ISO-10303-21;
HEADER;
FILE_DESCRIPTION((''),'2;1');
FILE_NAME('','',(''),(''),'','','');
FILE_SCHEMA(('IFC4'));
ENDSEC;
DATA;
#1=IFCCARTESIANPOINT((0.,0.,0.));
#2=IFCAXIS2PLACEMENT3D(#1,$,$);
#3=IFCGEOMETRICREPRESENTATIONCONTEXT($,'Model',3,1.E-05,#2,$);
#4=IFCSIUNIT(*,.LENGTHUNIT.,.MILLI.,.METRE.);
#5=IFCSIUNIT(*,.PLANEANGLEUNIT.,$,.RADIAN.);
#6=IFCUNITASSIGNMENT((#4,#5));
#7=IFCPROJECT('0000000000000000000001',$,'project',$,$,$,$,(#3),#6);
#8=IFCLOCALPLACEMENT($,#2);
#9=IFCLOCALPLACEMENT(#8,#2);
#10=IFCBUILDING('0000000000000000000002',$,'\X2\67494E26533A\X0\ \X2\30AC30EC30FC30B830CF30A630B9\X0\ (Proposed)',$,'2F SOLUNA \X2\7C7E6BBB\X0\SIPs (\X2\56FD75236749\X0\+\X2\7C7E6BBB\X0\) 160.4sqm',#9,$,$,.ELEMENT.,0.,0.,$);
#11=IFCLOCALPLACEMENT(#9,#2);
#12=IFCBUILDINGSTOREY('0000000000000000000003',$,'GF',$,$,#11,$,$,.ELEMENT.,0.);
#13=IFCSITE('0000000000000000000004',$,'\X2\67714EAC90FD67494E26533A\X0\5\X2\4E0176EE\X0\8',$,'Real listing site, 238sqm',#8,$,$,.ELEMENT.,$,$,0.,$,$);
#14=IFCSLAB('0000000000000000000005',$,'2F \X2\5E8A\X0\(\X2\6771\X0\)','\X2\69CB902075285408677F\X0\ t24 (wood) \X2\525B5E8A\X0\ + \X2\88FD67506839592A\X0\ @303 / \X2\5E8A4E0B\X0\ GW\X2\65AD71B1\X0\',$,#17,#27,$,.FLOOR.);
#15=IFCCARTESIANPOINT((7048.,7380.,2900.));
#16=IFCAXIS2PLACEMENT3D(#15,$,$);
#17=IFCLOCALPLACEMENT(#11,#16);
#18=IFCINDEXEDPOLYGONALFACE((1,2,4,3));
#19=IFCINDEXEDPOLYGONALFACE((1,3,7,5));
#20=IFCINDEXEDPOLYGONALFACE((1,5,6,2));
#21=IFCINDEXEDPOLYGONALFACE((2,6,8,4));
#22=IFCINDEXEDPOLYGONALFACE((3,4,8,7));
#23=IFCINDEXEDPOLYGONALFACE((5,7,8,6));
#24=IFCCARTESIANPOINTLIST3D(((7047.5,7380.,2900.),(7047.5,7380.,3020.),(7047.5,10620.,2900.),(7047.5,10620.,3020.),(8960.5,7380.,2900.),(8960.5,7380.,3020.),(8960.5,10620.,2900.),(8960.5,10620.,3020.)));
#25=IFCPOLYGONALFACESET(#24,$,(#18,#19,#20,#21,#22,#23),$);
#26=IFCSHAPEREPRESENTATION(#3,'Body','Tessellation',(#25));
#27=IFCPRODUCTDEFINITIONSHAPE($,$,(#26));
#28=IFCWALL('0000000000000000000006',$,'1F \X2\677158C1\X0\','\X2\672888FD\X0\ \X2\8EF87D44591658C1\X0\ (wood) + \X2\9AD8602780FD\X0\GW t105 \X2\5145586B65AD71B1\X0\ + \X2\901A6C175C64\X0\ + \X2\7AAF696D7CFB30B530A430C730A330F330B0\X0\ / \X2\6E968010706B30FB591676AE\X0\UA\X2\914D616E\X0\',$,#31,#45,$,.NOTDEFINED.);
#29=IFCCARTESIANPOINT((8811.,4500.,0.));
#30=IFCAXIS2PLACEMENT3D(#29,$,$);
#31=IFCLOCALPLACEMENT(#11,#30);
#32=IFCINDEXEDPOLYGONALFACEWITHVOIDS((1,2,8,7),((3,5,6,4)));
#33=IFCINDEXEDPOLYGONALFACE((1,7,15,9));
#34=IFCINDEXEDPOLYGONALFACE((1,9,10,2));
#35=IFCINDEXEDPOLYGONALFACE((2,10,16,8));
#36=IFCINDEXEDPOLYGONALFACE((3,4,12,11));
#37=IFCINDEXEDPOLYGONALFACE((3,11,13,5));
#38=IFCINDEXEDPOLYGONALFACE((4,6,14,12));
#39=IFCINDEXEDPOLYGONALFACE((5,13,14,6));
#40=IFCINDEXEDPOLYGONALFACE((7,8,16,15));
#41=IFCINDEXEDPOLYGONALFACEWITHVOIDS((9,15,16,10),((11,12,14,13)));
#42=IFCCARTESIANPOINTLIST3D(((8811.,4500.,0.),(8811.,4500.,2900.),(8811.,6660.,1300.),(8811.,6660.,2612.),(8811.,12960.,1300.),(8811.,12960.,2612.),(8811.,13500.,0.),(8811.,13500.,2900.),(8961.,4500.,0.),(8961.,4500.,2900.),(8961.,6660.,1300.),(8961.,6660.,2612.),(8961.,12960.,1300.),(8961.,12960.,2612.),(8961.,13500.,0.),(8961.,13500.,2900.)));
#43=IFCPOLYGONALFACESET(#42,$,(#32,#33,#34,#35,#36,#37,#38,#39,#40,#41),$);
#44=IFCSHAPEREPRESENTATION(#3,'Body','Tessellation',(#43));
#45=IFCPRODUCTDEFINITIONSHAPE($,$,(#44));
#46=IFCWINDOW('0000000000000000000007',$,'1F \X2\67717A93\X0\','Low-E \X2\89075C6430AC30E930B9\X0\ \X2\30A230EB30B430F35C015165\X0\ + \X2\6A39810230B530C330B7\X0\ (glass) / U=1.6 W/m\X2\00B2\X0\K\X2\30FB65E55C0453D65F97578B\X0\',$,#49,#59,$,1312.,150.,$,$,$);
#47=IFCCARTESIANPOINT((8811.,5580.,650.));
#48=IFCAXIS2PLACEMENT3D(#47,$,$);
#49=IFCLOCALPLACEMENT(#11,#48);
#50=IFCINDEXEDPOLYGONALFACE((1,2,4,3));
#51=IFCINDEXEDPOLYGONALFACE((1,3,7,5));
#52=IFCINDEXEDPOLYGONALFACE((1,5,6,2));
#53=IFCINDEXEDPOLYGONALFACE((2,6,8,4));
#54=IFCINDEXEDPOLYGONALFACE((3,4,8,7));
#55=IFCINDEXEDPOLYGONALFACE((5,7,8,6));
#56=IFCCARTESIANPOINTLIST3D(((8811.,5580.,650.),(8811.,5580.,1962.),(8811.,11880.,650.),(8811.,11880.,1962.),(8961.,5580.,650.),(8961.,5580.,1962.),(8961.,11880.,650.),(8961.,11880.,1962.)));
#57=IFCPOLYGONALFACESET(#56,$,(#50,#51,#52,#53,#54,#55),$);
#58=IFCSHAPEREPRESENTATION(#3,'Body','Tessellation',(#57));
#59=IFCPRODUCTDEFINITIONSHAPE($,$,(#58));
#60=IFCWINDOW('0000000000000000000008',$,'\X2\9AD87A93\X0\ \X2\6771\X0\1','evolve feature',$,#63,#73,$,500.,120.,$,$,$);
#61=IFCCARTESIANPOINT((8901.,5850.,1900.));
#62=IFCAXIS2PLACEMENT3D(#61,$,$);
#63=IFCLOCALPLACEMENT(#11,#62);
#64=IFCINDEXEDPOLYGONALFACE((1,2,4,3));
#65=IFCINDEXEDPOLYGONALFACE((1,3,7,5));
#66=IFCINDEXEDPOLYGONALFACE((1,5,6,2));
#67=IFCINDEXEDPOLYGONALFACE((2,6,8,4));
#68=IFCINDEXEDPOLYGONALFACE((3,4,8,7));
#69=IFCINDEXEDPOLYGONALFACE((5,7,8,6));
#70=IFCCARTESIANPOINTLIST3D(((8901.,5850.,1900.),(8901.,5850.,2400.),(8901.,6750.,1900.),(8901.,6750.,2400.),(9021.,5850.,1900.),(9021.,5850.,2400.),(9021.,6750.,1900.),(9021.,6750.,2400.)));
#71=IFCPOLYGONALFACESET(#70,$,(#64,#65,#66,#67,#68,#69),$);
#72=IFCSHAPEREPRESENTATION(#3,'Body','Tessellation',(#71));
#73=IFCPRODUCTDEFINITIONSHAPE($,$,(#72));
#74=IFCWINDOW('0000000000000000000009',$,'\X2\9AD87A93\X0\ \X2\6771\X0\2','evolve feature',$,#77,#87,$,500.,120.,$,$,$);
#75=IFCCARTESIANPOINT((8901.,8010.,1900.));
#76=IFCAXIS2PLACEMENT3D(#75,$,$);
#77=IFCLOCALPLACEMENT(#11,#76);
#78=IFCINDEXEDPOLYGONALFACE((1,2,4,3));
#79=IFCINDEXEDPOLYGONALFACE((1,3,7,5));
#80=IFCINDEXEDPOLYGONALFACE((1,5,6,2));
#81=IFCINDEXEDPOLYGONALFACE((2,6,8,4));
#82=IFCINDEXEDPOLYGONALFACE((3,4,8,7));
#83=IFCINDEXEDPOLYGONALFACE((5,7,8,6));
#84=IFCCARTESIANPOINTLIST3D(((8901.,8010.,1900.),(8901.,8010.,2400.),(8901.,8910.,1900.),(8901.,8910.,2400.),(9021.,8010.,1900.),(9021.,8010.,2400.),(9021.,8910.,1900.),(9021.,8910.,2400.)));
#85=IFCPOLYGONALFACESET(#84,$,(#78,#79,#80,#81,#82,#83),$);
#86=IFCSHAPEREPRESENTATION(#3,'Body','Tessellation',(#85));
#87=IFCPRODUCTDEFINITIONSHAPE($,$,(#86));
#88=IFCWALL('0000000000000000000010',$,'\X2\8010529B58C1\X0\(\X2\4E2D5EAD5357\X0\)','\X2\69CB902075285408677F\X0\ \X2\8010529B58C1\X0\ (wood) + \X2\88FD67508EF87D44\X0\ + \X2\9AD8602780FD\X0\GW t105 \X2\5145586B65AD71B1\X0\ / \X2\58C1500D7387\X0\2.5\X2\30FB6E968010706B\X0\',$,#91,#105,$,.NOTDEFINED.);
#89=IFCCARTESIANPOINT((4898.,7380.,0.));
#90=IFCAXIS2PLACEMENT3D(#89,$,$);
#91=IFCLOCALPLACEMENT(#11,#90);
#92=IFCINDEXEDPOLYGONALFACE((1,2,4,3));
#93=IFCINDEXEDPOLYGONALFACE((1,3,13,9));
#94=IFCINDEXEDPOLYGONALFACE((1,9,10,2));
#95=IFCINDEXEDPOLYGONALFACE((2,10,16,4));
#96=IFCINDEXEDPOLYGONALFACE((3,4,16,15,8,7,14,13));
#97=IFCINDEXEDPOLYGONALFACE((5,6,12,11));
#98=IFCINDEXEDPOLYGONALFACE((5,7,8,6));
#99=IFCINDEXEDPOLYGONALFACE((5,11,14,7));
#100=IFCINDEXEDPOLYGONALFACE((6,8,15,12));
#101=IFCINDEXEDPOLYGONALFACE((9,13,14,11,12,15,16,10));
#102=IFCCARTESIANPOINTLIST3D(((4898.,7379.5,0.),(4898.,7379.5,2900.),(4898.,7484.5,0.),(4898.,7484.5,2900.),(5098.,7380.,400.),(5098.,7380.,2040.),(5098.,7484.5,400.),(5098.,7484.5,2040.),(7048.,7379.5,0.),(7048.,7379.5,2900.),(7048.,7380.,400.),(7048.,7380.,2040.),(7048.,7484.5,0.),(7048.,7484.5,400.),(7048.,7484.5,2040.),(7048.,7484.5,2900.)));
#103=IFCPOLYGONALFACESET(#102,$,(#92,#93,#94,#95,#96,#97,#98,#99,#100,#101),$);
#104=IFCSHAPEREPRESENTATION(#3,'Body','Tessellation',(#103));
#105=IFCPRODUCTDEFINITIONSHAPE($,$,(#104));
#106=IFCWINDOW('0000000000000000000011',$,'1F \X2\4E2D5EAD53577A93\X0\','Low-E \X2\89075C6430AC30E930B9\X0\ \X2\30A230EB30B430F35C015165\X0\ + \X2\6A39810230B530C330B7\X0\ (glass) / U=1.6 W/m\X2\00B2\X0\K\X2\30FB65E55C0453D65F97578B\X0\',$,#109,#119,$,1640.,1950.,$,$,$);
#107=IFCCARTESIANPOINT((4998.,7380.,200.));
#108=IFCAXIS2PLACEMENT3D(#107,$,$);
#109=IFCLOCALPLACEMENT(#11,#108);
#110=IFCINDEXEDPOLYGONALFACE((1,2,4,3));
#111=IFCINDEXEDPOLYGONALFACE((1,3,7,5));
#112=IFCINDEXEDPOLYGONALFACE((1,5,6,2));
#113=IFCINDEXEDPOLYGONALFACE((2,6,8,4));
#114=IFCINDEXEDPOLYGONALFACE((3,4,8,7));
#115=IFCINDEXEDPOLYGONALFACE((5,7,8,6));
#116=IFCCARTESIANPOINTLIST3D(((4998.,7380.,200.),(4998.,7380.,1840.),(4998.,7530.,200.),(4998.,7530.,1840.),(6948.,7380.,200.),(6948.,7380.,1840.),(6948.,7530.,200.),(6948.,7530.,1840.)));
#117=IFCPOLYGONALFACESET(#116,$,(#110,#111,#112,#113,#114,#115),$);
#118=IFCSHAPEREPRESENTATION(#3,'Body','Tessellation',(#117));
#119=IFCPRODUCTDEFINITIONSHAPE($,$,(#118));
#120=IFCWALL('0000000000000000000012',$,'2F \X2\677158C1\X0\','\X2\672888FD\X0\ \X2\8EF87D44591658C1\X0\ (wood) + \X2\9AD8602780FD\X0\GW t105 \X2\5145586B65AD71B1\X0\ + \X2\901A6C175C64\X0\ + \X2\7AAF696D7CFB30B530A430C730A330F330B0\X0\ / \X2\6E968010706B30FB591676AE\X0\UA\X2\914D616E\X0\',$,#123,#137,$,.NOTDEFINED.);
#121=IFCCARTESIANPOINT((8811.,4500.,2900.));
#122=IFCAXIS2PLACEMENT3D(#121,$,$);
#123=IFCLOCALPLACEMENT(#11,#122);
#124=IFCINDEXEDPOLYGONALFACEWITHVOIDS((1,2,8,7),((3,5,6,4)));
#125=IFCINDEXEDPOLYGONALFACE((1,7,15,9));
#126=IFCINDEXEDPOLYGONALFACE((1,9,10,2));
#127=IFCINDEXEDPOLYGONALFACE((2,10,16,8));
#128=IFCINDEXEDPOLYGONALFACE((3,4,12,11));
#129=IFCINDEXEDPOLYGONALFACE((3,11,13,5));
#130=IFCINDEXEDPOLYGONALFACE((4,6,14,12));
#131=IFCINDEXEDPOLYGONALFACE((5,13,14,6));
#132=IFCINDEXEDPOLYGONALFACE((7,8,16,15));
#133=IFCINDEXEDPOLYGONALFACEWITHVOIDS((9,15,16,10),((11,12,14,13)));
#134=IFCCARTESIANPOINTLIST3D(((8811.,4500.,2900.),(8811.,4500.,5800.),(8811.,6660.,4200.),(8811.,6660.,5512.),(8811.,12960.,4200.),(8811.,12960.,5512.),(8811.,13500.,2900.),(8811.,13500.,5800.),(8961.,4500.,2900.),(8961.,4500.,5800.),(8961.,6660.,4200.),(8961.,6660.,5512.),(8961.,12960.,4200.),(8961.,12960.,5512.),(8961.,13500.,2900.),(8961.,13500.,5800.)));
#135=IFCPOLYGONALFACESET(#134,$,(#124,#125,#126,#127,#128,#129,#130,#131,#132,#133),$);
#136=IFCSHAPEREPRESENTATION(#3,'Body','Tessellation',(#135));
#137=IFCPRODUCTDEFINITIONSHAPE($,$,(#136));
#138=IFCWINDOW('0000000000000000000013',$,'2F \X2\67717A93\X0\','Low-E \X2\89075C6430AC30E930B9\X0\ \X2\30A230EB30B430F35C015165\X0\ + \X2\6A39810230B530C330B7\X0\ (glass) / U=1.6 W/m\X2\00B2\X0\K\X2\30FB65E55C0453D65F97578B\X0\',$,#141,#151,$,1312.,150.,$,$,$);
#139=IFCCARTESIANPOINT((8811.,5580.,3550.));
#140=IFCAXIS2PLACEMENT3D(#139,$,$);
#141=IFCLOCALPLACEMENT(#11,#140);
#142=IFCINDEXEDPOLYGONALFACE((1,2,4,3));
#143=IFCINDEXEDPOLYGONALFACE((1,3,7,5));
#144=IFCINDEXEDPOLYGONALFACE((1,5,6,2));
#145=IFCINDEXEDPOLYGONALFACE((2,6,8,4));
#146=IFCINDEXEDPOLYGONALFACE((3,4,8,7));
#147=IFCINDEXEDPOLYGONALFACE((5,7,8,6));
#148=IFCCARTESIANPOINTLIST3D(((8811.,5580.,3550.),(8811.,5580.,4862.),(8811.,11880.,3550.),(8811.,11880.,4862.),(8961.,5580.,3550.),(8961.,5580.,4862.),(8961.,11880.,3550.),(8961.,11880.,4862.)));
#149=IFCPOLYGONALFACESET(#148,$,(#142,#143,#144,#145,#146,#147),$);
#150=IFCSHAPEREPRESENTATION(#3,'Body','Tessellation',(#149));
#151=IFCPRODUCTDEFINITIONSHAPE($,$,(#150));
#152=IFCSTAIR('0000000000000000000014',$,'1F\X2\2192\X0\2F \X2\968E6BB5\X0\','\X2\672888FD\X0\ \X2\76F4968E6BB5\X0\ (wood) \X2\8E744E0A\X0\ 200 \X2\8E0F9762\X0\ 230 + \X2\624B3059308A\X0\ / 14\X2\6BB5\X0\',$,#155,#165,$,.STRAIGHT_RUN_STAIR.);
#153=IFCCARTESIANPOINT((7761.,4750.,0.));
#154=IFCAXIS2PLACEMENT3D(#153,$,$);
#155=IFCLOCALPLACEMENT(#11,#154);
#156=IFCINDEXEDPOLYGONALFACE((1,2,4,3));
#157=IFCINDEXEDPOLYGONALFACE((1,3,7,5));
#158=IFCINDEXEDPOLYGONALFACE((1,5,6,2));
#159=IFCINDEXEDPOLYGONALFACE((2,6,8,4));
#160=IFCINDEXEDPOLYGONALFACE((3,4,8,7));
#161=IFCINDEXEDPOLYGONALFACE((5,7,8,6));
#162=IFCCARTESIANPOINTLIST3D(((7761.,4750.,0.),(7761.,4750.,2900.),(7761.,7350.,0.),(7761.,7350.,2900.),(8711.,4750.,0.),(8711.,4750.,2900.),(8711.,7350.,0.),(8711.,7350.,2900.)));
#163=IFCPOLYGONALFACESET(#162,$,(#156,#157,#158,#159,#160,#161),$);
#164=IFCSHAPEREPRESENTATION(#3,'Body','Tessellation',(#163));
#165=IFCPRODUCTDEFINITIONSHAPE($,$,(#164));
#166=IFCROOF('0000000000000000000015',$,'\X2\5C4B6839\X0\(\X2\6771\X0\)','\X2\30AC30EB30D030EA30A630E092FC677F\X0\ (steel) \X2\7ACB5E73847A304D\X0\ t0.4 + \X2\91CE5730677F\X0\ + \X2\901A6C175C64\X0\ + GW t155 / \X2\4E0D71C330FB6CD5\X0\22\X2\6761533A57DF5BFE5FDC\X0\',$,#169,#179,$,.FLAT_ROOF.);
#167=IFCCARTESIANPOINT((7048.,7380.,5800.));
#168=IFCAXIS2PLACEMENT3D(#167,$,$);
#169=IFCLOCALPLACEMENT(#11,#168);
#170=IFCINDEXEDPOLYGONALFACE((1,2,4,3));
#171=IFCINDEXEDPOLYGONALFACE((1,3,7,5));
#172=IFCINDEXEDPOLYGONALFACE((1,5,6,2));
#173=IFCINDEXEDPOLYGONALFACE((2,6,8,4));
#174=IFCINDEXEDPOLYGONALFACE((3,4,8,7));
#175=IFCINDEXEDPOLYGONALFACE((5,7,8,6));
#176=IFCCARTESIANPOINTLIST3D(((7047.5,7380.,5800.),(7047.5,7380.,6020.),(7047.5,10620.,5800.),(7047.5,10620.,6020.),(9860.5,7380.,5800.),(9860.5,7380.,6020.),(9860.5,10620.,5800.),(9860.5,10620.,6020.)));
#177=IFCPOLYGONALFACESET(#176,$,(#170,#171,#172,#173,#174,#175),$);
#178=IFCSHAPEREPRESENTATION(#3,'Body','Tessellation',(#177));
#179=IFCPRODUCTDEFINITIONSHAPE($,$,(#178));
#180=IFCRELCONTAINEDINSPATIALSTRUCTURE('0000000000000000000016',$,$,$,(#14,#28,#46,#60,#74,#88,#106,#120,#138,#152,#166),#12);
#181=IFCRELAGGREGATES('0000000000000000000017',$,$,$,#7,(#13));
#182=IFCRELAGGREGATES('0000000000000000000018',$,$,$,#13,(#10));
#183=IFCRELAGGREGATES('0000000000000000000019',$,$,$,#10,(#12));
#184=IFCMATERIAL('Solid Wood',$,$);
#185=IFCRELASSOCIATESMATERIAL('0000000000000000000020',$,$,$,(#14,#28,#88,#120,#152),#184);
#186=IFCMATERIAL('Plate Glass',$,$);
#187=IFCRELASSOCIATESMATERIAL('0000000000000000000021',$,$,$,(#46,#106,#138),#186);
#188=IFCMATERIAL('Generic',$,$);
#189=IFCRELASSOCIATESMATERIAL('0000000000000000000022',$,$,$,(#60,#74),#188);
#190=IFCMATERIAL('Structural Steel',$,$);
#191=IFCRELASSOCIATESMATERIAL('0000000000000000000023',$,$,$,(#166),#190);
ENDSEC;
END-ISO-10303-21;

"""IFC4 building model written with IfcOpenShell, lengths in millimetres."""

from ifc_helpers import new_model, si_unit, frame, frame_2d, origin, place, context, project, spatial, rectangle, extrude, material, element, fill, save


model = new_model("IFC4")

# Units and contexts
model_context = context("Model", 3, precision=1e-05, world=origin())
ifc_project = project(units=[si_unit("LENGTHUNIT", "METRE", prefix="MILLI"), si_unit("PLANEANGLEUNIT", "RADIAN")], contexts=[model_context])

# Site, building, storey
site_placement = place(None, origin())
site = spatial("IfcSite", under=ifc_project, at=site_placement, Name="東京都杉並区5丁目8", ObjectType="Real listing site, 238sqm", CompositionType="ELEMENT", RefElevation=0.0)
building_placement = place(site_placement, origin())
building = spatial("IfcBuilding", under=site, at=building_placement, Name="杉並区 ガレージハウス (Proposed)", ObjectType="2F SOLUNA 籾殻SIPs (国産杉+籾殻) 160.4sqm", CompositionType="ELEMENT", ElevationOfRefHeight=0.0, ElevationOfTerrain=0.0)
storey_placement = place(building_placement, origin())
storey = spatial("IfcBuildingStorey", under=building, at=storey_placement, Name="GF", CompositionType="ELEMENT", Elevation=0.0)

# Slab
ifc_material_1 = material(Name="Solid Wood")
slab_1_placement = place(storey_placement, frame((7048.0, 7380.0, 2900.0)))
element("IfcSlab", 1, at=slab_1_placement, inside=storey, material=ifc_material_1, Name="2F 床(東)", Description="構造用合板 t24 (wood) 剛床 + 製材根太 @303 / 床下 GW断熱", PredefinedType="FLOOR", context=model_context, shape_type="SweptSolid", body=[
    extrude(rectangle(XDim=1913.0, YDim=3240.0, at=frame_2d((956.0, 1620.0))), frame((7048.0, 7380.0, 2900.0)), (0.0, 0.0, 1.0), 120.0),
])

# Wall, openings, windows
wall_1_placement = place(storey_placement, frame((8811.0, 4500.0, 0.0)))
wall_1 = element("IfcWall", 2, at=wall_1_placement, inside=storey, material=ifc_material_1, Name="1F 東壁", Description="木製 軸組外壁 (wood) + 高性能GW t105 充填断熱 + 通気層 + 窯業系サイディング / 準耐火・外皮UA配慮", PredefinedType="NOTDEFINED", context=model_context, shape_type="SweptSolid", body=[
    extrude(rectangle(XDim=150.0, YDim=9000.0, at=frame_2d((75.0, 4500.0))), frame((8811.0, 4500.0, 0.0)), (0.0, 0.0, 1.0), 2900.0),
])
opening_1_placement = place(storey_placement, frame((8811.0, 5580.0, 650.0)))
opening_1 = element("IfcOpeningElement", 3, at=opening_1_placement, cuts=wall_1, PredefinedType="NOTDEFINED", context=model_context, shape_type="SweptSolid", body=[
    extrude(rectangle(XDim=150.0, YDim=6300.0, at=frame_2d((75.0, 3150.0))), frame((8811.0, 5580.0, 650.0)), (0.0, 0.0, 1.0), 1312.0),
])
opening_2_placement = place(storey_placement, frame((8901.0, 5850.0, 1900.0)))
opening_2 = element("IfcOpeningElement", 4, at=opening_2_placement, cuts=wall_1, PredefinedType="NOTDEFINED", context=model_context, shape_type="SweptSolid", body=[
    extrude(rectangle(XDim=120.0, YDim=900.0, at=frame_2d((60.0, 450.0))), frame((8901.0, 5850.0, 1900.0)), (0.0, 0.0, 1.0), 500.0),
])
opening_3_placement = place(storey_placement, frame((8901.0, 8010.0, 1900.0)))
opening_3 = element("IfcOpeningElement", 5, at=opening_3_placement, cuts=wall_1, PredefinedType="NOTDEFINED", context=model_context, shape_type="SweptSolid", body=[
    extrude(rectangle(XDim=120.0, YDim=900.0, at=frame_2d((60.0, 450.0))), frame((8901.0, 8010.0, 1900.0)), (0.0, 0.0, 1.0), 500.0),
])
ifc_material_2 = material(Name="Plate Glass")
window_1_placement = place(storey_placement, frame((8811.0, 5580.0, 650.0)))
window_1 = element("IfcWindow", 6, at=window_1_placement, inside=storey, material=ifc_material_2, Name="1F 東窓", Description="Low-E 複層ガラス アルゴン封入 + 樹脂サッシ (glass) / U=1.6 W/m²K・日射取得型", OverallHeight=1312.0, OverallWidth=150.0, context=model_context, shape_type="SweptSolid", body=[
    extrude(rectangle(XDim=150.0, YDim=6300.0, at=frame_2d((75.0, 3150.0))), frame((8811.0, 5580.0, 650.0)), (0.0, 0.0, 1.0), 1312.0),
])
fill(opening_1, window_1)
ifc_material_3 = material(Name="Generic")
window_2_placement = place(storey_placement, frame((8901.0, 5850.0, 1900.0)))
window_2 = element("IfcWindow", 7, at=window_2_placement, inside=storey, material=ifc_material_3, Name="高窓 東1", Description="evolve feature", OverallHeight=500.0, OverallWidth=120.0, context=model_context, shape_type="SweptSolid", body=[
    extrude(rectangle(XDim=120.0, YDim=900.0, at=frame_2d((60.0, 450.0))), frame((8901.0, 5850.0, 1900.0)), (0.0, 0.0, 1.0), 500.0),
])
fill(opening_2, window_2)
window_3_placement = place(storey_placement, frame((8901.0, 8010.0, 1900.0)))
window_3 = element("IfcWindow", 8, at=window_3_placement, inside=storey, material=ifc_material_3, Name="高窓 東2", Description="evolve feature", OverallHeight=500.0, OverallWidth=120.0, context=model_context, shape_type="SweptSolid", body=[
    extrude(rectangle(XDim=120.0, YDim=900.0, at=frame_2d((60.0, 450.0))), frame((8901.0, 8010.0, 1900.0)), (0.0, 0.0, 1.0), 500.0),
])
fill(opening_3, window_3)

# Wall, opening, window
wall_2_placement = place(storey_placement, frame((4898.0, 7380.0, 0.0)))
wall_2 = element("IfcWall", 9, at=wall_2_placement, inside=storey, material=ifc_material_1, Name="耐力壁(中庭南)", Description="構造用合板 耐力壁 (wood) + 製材軸組 + 高性能GW t105 充填断熱 / 壁倍率2.5・準耐火", PredefinedType="NOTDEFINED", context=model_context, shape_type="SweptSolid", body=[
    extrude(rectangle(XDim=2150.0, YDim=105.0, at=frame_2d((1075.0, 52.0))), frame((4898.0, 7380.0, 0.0)), (0.0, 0.0, 1.0), 2900.0),
])
opening_4_placement = place(storey_placement, frame((4998.0, 7380.0, 200.0)))
opening_4 = element("IfcOpeningElement", 10, at=opening_4_placement, cuts=wall_2, PredefinedType="NOTDEFINED", context=model_context, shape_type="SweptSolid", body=[
    extrude(rectangle(XDim=1950.0, YDim=150.0, at=frame_2d((975.0, 75.0))), frame((4998.0, 7380.0, 200.0)), (0.0, 0.0, 1.0), 1640.0),
])
window_4_placement = place(storey_placement, frame((4998.0, 7380.0, 200.0)))
window_4 = element("IfcWindow", 11, at=window_4_placement, inside=storey, material=ifc_material_2, Name="1F 中庭南窓", Description="Low-E 複層ガラス アルゴン封入 + 樹脂サッシ (glass) / U=1.6 W/m²K・日射取得型", OverallHeight=1640.0, OverallWidth=1950.0, context=model_context, shape_type="SweptSolid", body=[
    extrude(rectangle(XDim=1950.0, YDim=150.0, at=frame_2d((975.0, 75.0))), frame((4998.0, 7380.0, 200.0)), (0.0, 0.0, 1.0), 1640.0),
])
fill(opening_4, window_4)

# Wall, opening, window
wall_3_placement = place(storey_placement, frame((8811.0, 4500.0, 2900.0)))
wall_3 = element("IfcWall", 12, at=wall_3_placement, inside=storey, material=ifc_material_1, Name="2F 東壁", Description="木製 軸組外壁 (wood) + 高性能GW t105 充填断熱 + 通気層 + 窯業系サイディング / 準耐火・外皮UA配慮", PredefinedType="NOTDEFINED", context=model_context, shape_type="SweptSolid", body=[
    extrude(rectangle(XDim=150.0, YDim=9000.0, at=frame_2d((75.0, 4500.0))), frame((8811.0, 4500.0, 2900.0)), (0.0, 0.0, 1.0), 2900.0),
])
opening_5_placement = place(storey_placement, frame((8811.0, 5580.0, 3550.0)))
opening_5 = element("IfcOpeningElement", 13, at=opening_5_placement, cuts=wall_3, PredefinedType="NOTDEFINED", context=model_context, shape_type="SweptSolid", body=[
    extrude(rectangle(XDim=150.0, YDim=6300.0, at=frame_2d((75.0, 3150.0))), frame((8811.0, 5580.0, 3550.0)), (0.0, 0.0, 1.0), 1312.0),
])
window_5_placement = place(storey_placement, frame((8811.0, 5580.0, 3550.0)))
window_5 = element("IfcWindow", 14, at=window_5_placement, inside=storey, material=ifc_material_2, Name="2F 東窓", Description="Low-E 複層ガラス アルゴン封入 + 樹脂サッシ (glass) / U=1.6 W/m²K・日射取得型", OverallHeight=1312.0, OverallWidth=150.0, context=model_context, shape_type="SweptSolid", body=[
    extrude(rectangle(XDim=150.0, YDim=6300.0, at=frame_2d((75.0, 3150.0))), frame((8811.0, 5580.0, 3550.0)), (0.0, 0.0, 1.0), 1312.0),
])
fill(opening_5, window_5)

# Stair
stair_placement = place(storey_placement, frame((7761.0, 4750.0, 0.0)))
element("IfcStair", 15, at=stair_placement, inside=storey, material=ifc_material_1, Name="1F→2F 階段", Description="木製 直階段 (wood) 蹴上 200 踏面 230 + 手すり / 14段", PredefinedType="STRAIGHT_RUN_STAIR", context=model_context, shape_type="SweptSolid", body=[
    extrude(rectangle(XDim=950.0, YDim=2600.0, at=frame_2d((475.0, 1300.0))), frame((7761.0, 4750.0, 0.0)), (0.0, 0.0, 1.0), 2900.0),
])

# Roof
ifc_material_4 = material(Name="Structural Steel")
roof_placement = place(storey_placement, frame((7048.0, 7380.0, 5800.0)))
element("IfcRoof", 16, at=roof_placement, inside=storey, material=ifc_material_4, Name="屋根(東)", Description="ガルバリウム鋼板 (steel) 立平葺き t0.4 + 野地板 + 通気層 + GW t155 / 不燃・法22条区域対応", PredefinedType="FLAT_ROOF", context=model_context, shape_type="SweptSolid", body=[
    extrude(rectangle(XDim=2813.0, YDim=3240.0, at=frame_2d((1406.0, 1620.0))), frame((7048.0, 7380.0, 5800.0)), (0.0, 0.0, 1.0), 220.0),
])

save(model, "model.ifc")
